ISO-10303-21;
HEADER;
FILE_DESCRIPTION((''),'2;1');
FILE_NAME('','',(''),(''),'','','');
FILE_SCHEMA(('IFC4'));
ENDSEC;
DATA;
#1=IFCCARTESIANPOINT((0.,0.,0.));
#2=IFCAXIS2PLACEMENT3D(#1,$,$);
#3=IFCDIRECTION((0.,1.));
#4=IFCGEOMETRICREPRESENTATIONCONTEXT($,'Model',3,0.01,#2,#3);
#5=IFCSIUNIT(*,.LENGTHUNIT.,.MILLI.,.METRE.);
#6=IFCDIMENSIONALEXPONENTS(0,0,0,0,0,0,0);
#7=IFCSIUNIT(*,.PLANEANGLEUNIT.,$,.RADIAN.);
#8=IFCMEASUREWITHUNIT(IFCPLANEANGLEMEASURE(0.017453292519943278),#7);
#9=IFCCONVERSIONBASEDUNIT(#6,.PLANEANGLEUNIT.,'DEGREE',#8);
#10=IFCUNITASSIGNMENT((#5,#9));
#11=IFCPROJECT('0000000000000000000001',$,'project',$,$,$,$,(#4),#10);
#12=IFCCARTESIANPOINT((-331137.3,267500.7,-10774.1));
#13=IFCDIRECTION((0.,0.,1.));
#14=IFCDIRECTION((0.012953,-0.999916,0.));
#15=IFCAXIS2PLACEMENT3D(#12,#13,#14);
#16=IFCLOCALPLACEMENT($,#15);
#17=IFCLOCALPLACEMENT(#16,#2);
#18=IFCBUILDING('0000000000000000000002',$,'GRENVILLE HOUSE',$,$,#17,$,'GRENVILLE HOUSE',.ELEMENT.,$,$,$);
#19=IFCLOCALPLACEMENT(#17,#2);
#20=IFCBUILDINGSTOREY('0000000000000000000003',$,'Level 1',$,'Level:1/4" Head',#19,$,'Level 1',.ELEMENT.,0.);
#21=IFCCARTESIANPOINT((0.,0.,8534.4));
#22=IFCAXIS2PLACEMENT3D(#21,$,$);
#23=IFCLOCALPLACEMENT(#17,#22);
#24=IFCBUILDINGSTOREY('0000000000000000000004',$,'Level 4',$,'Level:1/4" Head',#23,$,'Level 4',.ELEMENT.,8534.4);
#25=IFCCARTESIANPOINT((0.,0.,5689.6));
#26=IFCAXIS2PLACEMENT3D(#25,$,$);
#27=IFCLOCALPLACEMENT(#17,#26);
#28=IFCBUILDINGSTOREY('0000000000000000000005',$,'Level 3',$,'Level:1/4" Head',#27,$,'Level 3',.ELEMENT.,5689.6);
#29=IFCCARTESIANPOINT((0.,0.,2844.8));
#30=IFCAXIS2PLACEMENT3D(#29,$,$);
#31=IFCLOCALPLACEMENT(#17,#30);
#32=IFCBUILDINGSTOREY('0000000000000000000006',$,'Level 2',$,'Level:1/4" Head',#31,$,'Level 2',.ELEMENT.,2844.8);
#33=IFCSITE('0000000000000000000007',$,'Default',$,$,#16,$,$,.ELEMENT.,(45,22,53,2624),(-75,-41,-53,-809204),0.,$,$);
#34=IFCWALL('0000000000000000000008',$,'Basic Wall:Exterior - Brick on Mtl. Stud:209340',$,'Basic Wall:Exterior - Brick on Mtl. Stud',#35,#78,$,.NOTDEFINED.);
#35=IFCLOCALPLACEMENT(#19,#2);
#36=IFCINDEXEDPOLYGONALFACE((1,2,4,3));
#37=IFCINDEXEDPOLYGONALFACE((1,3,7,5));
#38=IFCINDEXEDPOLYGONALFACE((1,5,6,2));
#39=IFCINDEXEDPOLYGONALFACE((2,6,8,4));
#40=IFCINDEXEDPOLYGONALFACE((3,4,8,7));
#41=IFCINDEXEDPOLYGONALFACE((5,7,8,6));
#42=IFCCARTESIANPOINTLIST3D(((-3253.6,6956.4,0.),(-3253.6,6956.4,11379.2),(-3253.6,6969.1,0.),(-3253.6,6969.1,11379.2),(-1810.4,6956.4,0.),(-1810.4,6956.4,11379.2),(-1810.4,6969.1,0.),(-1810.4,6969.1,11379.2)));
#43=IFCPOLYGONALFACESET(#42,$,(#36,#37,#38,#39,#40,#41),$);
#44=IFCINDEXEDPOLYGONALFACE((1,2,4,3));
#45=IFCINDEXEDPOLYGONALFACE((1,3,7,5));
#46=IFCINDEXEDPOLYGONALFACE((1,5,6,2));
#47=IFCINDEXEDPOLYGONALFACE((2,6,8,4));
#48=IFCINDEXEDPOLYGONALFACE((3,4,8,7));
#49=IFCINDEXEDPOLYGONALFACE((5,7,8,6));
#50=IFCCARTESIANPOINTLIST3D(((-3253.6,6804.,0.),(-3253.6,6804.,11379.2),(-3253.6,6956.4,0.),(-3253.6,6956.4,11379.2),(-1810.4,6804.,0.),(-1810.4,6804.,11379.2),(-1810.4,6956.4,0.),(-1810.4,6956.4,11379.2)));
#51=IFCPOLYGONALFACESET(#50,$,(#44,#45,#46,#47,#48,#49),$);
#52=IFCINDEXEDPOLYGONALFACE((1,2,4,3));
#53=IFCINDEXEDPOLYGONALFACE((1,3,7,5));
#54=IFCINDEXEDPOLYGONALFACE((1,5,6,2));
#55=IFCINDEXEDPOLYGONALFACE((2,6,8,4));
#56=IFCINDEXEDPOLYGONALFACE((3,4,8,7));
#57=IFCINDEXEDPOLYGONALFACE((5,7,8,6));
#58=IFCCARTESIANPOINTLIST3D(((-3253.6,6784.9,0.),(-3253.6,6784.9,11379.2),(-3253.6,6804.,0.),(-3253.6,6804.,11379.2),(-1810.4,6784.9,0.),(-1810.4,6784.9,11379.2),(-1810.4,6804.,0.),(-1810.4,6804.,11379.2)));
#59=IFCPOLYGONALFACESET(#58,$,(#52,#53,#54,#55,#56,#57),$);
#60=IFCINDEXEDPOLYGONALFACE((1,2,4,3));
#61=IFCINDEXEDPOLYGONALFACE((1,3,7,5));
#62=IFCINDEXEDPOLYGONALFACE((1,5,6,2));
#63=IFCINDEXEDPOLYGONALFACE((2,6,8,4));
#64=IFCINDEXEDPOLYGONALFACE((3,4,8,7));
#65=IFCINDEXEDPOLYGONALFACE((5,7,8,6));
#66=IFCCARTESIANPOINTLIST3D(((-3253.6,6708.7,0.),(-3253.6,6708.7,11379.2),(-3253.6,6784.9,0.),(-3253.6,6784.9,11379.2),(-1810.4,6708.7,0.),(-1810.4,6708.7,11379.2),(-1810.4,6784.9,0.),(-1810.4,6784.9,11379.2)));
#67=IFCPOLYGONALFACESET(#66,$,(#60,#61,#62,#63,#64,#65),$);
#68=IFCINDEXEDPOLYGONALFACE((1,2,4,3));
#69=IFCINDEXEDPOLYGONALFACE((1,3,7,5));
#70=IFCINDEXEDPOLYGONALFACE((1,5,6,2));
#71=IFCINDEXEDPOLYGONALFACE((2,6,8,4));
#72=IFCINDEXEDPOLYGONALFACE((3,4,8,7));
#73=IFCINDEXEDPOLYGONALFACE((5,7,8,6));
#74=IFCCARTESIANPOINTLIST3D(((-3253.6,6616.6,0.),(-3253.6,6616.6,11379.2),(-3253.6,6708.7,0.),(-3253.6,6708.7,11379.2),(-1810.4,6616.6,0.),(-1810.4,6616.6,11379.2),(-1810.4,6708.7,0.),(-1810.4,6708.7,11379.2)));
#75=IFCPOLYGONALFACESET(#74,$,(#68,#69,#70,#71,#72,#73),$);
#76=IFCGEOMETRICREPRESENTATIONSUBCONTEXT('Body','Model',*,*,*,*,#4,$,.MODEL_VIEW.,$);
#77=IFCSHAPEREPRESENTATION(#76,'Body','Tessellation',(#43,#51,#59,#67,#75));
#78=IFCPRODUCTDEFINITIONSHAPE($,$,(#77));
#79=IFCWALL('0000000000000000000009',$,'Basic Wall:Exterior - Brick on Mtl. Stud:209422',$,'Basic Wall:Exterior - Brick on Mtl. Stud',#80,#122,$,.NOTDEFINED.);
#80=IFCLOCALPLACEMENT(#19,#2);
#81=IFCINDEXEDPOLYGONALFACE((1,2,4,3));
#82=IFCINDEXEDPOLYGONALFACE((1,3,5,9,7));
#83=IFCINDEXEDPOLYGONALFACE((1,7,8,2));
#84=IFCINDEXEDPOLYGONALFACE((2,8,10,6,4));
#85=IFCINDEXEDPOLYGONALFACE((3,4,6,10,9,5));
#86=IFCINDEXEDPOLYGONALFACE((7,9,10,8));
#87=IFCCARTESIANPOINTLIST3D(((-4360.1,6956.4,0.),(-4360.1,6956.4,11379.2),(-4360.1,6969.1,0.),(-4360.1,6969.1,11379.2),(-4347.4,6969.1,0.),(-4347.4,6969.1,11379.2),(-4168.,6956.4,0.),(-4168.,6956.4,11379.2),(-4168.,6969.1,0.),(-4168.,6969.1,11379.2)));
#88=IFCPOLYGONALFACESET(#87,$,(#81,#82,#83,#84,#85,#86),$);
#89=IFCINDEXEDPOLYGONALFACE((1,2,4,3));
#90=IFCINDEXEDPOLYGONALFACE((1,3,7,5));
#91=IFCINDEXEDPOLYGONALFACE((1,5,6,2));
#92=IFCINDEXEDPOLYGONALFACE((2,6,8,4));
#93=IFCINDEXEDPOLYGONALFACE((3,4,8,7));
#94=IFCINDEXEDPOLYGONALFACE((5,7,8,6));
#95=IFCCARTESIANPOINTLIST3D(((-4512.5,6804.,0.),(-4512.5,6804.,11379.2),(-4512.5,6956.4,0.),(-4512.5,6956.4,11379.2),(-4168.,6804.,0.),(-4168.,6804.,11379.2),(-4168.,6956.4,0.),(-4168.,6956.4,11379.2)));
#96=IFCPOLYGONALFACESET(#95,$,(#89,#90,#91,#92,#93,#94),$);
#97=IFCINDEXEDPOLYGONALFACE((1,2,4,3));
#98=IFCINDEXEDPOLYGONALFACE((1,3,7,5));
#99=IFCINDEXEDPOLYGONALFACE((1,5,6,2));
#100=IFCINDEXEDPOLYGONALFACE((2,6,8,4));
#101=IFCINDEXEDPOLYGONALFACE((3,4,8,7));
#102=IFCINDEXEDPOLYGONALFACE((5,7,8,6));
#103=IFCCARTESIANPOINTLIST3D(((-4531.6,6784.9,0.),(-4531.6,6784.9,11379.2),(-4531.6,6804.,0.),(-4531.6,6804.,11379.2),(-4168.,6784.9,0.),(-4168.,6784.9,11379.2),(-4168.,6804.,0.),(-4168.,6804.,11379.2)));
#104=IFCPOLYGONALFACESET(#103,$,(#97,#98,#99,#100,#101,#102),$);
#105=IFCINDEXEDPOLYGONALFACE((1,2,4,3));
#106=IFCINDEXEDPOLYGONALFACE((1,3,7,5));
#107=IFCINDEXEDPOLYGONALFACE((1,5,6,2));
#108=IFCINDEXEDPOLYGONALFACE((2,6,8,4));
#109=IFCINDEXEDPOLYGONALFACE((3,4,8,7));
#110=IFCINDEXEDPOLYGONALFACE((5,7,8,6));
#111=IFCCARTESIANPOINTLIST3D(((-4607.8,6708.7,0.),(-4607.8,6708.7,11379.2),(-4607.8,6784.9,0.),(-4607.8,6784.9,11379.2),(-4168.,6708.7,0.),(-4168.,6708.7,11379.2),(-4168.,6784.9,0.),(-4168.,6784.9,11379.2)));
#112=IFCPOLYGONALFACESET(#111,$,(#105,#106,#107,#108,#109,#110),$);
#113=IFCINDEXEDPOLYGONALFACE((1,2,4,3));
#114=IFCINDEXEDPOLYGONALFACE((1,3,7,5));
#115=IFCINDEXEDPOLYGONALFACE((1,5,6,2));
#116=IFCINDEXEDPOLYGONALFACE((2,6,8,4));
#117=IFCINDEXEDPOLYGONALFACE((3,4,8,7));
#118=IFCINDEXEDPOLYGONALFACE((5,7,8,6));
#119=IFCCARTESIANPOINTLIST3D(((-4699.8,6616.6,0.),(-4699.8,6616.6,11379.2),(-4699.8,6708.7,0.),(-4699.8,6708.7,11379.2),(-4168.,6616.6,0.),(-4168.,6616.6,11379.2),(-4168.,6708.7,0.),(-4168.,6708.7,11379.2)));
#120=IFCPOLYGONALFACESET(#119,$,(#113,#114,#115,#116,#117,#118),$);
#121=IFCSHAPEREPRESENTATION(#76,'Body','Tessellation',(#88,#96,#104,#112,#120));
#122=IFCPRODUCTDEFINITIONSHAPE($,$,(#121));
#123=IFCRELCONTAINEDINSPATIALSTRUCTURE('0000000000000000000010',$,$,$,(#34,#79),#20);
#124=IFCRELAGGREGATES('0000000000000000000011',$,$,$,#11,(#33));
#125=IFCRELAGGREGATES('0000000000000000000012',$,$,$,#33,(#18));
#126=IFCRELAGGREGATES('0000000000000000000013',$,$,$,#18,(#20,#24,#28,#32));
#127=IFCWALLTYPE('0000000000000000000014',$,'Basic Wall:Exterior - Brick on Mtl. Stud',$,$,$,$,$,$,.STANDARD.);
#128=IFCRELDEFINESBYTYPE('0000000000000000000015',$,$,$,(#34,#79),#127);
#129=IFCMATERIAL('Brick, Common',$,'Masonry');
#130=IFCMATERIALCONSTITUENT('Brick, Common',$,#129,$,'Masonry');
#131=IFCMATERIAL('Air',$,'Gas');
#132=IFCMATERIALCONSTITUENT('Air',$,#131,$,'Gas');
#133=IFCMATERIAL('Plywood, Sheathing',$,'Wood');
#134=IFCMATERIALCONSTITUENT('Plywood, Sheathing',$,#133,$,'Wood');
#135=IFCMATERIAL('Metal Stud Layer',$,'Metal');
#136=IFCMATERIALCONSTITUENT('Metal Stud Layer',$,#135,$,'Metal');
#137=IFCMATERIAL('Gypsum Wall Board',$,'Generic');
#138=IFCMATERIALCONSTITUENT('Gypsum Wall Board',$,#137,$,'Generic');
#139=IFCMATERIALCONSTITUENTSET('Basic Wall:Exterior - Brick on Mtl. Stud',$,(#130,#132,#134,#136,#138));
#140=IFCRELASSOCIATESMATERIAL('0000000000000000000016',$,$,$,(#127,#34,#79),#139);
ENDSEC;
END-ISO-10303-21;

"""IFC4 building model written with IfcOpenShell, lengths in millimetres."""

from ifc_helpers import new_model, entity, si_unit, converted_unit, direction, frame, origin, place, context, subcontext, project, spatial, indexed_curve, outline, extrude, material, constituent, constituent_set, type_object, element, save


model = new_model("IFC4")

# Units and contexts
model_context = context("Model", 3, precision=0.01, world=origin(), true_north=direction((0.0, 1.0)))
body_context = subcontext(model_context, "Body", "Model", "MODEL_VIEW")
ifc_project = project(units=[si_unit("LENGTHUNIT", "METRE", prefix="MILLI"), converted_unit("PLANEANGLEUNIT", "DEGREE", entity("IfcPlaneAngleMeasure", 0.017453292519943278), si_unit("PLANEANGLEUNIT", "RADIAN"), dimensions=[0, 0, 0, 0, 0, 0, 0])], contexts=[model_context])

# Site, building, storey
site_placement = place(None, frame((-331137.3, 267500.7, -10774.1), z_axis=(0.0, 0.0, 1.0), x_axis=(0.012953, -0.999916, 0.0)))
site = spatial("IfcSite", under=ifc_project, at=site_placement, Name="Default", CompositionType="ELEMENT", RefLatitude=(45, 22, 53, 2624), RefLongitude=(-75, -41, -53, -809204), RefElevation=0.0)
building_placement = place(site_placement, origin())
building = spatial("IfcBuilding", under=site, at=building_placement, Name="GRENVILLE HOUSE", LongName="GRENVILLE HOUSE", CompositionType="ELEMENT")
storey_1_placement = place(building_placement, origin())
storey_1 = spatial("IfcBuildingStorey", under=building, at=storey_1_placement, Name="Level 1", ObjectType="Level:1/4\" Head", LongName="Level 1", CompositionType="ELEMENT", Elevation=0.0)

# Shared definitions
ifc_material_1 = material(Name="Brick, Common", Category="Masonry")
ifc_constituent_1 = constituent(ifc_material_1, Name="Brick, Common", Category="Masonry")
ifc_material_2 = material(Name="Air", Category="Gas")
ifc_constituent_2 = constituent(ifc_material_2, Name="Air", Category="Gas")
ifc_material_3 = material(Name="Plywood, Sheathing", Category="Wood")
ifc_constituent_3 = constituent(ifc_material_3, Name="Plywood, Sheathing", Category="Wood")
ifc_material_4 = material(Name="Metal Stud Layer", Category="Metal")
ifc_constituent_4 = constituent(ifc_material_4, Name="Metal Stud Layer", Category="Metal")
ifc_material_5 = material(Name="Gypsum Wall Board", Category="Generic")
ifc_constituent_5 = constituent(ifc_material_5, Name="Gypsum Wall Board", Category="Generic")
ifc_constituent_set_1 = constituent_set(constituents=[ifc_constituent_1, ifc_constituent_2, ifc_constituent_3, ifc_constituent_4, ifc_constituent_5], Name="Basic Wall:Exterior - Brick on Mtl. Stud")
wall_type_1 = type_object("IfcWallType", Name="Basic Wall:Exterior - Brick on Mtl. Stud", PredefinedType="STANDARD", material=ifc_constituent_set_1)

# Shared definitions
storey_2_placement = place(building_placement, frame((0.0, 0.0, 8534.4)))
storey_2 = spatial("IfcBuildingStorey", under=building, at=storey_2_placement, Name="Level 4", ObjectType="Level:1/4\" Head", LongName="Level 4", CompositionType="ELEMENT", Elevation=8534.4)

# Shared definitions
storey_3_placement = place(building_placement, frame((0.0, 0.0, 5689.6)))
storey_3 = spatial("IfcBuildingStorey", under=building, at=storey_3_placement, Name="Level 3", ObjectType="Level:1/4\" Head", LongName="Level 3", CompositionType="ELEMENT", Elevation=5689.6)

# Shared definitions
storey_4_placement = place(building_placement, frame((0.0, 0.0, 2844.8)))
storey_4 = spatial("IfcBuildingStorey", under=building, at=storey_4_placement, Name="Level 2", ObjectType="Level:1/4\" Head", LongName="Level 2", CompositionType="ELEMENT", Elevation=2844.8)

# Walls
wall_1_placement = place(storey_1_placement, frame((-3253.6, 6792.8, 0.0)))
element("IfcWall", 1, at=wall_1_placement, inside=storey_1, type_object=wall_type_1, material=ifc_constituent_set_1, Name="Basic Wall:Exterior - Brick on Mtl. Stud:209340", ObjectType="Basic Wall:Exterior - Brick on Mtl. Stud", PredefinedType="NOTDEFINED", context=body_context, shape_type="SweptSolid", body=[
    extrude(outline(indexed_curve([(-6.4, -721.6), (6.3, -721.6), (6.4, 721.6), (-6.3, 721.6), (-6.4, -721.6)], self_intersect=False)), frame((721.6, 169.9, 0.0), z_axis=(0.0, 0.0, 1.0), x_axis=(0.0, -1.0, 0.0)), (0.0, 0.0, 1.0), 11379.2),
    extrude(outline(indexed_curve([(-721.6, -76.2), (721.6, -76.2), (721.6, 76.2), (-721.6, 76.2), (-721.6, -76.2)], self_intersect=False)), frame((721.6, 87.3, 0.0)), (0.0, 0.0, 1.0), 11379.2),
    extrude(outline(indexed_curve([(-721.6, -9.5), (721.6, -9.5), (721.6, 9.5), (-721.6, 9.5), (-721.6, -9.5)], self_intersect=False)), frame((721.6, 1.6, 0.0)), (0.0, 0.0, 1.0), 11379.2),
    extrude(outline(indexed_curve([(-721.6, -38.1), (721.6, -38.1), (721.6, 38.1), (-721.6, 38.1), (-721.6, -38.1)], self_intersect=False)), frame((721.6, -46.0, 0.0)), (0.0, 0.0, 1.0), 11379.2),
    extrude(outline(indexed_curve([(-46.0, -721.6), (46.0, -721.6), (46.0, 721.6), (-46.0, 721.6), (-46.0, -721.6)], self_intersect=False)), frame((721.6, -130.2, 0.0), z_axis=(0.0, 0.0, 1.0), x_axis=(0.0, 1.0, 0.0)), (0.0, 0.0, 1.0), 11379.2),
])
wall_2_placement = place(storey_1_placement, frame((-4168.0, 6792.8, 0.0), z_axis=(0.0, 0.0, 1.0), x_axis=(-1.0, 0.0, 0.0)))
element("IfcWall", 2, at=wall_2_placement, inside=storey_1, type_object=wall_type_1, material=ifc_constituent_set_1, Name="Basic Wall:Exterior - Brick on Mtl. Stud:209422", ObjectType="Basic Wall:Exterior - Brick on Mtl. Stud", PredefinedType="NOTDEFINED", context=body_context, shape_type="SweptSolid", body=[
    extrude(outline(indexed_curve([(66.7, -5.1), (79.4, -5.1), (79.4, 7.6), (-112.7, 7.6), (-112.7, -5.1), (66.7, -5.1)], self_intersect=False)), frame((112.7, -171.1, 0.0)), (0.0, 0.0, 1.0), 11379.2),
    extrude(outline(indexed_curve([(-172.2, -76.2), (172.2, -76.2), (172.2, 76.2), (-172.2, 76.2), (-172.2, -76.2)], self_intersect=False)), frame((172.2, -87.3, 0.0)), (0.0, 0.0, 1.0), 11379.2),
    extrude(outline(indexed_curve([(-181.8, -9.5), (181.8, -9.5), (181.8, 9.5), (-181.8, 9.5), (-181.8, -9.5)], self_intersect=False)), frame((181.8, -1.6, 0.0)), (0.0, 0.0, 1.0), 11379.2),
    extrude(outline(indexed_curve([(-219.9, -38.1), (219.9, -38.1), (219.9, 38.1), (-219.9, 38.1), (-219.9, -38.1)], self_intersect=False)), frame((219.9, 46.0, 0.0)), (0.0, 0.0, 1.0), 11379.2),
    extrude(outline(indexed_curve([(-46.0, -265.9), (46.0, -265.9), (46.0, 265.9), (-46.0, 265.9), (-46.0, -265.9)], self_intersect=False)), frame((265.9, 130.2, 0.0), z_axis=(0.0, 0.0, 1.0), x_axis=(0.0, -1.0, 0.0)), (0.0, 0.0, 1.0), 11379.2),
])

save(model, "model.ifc")
